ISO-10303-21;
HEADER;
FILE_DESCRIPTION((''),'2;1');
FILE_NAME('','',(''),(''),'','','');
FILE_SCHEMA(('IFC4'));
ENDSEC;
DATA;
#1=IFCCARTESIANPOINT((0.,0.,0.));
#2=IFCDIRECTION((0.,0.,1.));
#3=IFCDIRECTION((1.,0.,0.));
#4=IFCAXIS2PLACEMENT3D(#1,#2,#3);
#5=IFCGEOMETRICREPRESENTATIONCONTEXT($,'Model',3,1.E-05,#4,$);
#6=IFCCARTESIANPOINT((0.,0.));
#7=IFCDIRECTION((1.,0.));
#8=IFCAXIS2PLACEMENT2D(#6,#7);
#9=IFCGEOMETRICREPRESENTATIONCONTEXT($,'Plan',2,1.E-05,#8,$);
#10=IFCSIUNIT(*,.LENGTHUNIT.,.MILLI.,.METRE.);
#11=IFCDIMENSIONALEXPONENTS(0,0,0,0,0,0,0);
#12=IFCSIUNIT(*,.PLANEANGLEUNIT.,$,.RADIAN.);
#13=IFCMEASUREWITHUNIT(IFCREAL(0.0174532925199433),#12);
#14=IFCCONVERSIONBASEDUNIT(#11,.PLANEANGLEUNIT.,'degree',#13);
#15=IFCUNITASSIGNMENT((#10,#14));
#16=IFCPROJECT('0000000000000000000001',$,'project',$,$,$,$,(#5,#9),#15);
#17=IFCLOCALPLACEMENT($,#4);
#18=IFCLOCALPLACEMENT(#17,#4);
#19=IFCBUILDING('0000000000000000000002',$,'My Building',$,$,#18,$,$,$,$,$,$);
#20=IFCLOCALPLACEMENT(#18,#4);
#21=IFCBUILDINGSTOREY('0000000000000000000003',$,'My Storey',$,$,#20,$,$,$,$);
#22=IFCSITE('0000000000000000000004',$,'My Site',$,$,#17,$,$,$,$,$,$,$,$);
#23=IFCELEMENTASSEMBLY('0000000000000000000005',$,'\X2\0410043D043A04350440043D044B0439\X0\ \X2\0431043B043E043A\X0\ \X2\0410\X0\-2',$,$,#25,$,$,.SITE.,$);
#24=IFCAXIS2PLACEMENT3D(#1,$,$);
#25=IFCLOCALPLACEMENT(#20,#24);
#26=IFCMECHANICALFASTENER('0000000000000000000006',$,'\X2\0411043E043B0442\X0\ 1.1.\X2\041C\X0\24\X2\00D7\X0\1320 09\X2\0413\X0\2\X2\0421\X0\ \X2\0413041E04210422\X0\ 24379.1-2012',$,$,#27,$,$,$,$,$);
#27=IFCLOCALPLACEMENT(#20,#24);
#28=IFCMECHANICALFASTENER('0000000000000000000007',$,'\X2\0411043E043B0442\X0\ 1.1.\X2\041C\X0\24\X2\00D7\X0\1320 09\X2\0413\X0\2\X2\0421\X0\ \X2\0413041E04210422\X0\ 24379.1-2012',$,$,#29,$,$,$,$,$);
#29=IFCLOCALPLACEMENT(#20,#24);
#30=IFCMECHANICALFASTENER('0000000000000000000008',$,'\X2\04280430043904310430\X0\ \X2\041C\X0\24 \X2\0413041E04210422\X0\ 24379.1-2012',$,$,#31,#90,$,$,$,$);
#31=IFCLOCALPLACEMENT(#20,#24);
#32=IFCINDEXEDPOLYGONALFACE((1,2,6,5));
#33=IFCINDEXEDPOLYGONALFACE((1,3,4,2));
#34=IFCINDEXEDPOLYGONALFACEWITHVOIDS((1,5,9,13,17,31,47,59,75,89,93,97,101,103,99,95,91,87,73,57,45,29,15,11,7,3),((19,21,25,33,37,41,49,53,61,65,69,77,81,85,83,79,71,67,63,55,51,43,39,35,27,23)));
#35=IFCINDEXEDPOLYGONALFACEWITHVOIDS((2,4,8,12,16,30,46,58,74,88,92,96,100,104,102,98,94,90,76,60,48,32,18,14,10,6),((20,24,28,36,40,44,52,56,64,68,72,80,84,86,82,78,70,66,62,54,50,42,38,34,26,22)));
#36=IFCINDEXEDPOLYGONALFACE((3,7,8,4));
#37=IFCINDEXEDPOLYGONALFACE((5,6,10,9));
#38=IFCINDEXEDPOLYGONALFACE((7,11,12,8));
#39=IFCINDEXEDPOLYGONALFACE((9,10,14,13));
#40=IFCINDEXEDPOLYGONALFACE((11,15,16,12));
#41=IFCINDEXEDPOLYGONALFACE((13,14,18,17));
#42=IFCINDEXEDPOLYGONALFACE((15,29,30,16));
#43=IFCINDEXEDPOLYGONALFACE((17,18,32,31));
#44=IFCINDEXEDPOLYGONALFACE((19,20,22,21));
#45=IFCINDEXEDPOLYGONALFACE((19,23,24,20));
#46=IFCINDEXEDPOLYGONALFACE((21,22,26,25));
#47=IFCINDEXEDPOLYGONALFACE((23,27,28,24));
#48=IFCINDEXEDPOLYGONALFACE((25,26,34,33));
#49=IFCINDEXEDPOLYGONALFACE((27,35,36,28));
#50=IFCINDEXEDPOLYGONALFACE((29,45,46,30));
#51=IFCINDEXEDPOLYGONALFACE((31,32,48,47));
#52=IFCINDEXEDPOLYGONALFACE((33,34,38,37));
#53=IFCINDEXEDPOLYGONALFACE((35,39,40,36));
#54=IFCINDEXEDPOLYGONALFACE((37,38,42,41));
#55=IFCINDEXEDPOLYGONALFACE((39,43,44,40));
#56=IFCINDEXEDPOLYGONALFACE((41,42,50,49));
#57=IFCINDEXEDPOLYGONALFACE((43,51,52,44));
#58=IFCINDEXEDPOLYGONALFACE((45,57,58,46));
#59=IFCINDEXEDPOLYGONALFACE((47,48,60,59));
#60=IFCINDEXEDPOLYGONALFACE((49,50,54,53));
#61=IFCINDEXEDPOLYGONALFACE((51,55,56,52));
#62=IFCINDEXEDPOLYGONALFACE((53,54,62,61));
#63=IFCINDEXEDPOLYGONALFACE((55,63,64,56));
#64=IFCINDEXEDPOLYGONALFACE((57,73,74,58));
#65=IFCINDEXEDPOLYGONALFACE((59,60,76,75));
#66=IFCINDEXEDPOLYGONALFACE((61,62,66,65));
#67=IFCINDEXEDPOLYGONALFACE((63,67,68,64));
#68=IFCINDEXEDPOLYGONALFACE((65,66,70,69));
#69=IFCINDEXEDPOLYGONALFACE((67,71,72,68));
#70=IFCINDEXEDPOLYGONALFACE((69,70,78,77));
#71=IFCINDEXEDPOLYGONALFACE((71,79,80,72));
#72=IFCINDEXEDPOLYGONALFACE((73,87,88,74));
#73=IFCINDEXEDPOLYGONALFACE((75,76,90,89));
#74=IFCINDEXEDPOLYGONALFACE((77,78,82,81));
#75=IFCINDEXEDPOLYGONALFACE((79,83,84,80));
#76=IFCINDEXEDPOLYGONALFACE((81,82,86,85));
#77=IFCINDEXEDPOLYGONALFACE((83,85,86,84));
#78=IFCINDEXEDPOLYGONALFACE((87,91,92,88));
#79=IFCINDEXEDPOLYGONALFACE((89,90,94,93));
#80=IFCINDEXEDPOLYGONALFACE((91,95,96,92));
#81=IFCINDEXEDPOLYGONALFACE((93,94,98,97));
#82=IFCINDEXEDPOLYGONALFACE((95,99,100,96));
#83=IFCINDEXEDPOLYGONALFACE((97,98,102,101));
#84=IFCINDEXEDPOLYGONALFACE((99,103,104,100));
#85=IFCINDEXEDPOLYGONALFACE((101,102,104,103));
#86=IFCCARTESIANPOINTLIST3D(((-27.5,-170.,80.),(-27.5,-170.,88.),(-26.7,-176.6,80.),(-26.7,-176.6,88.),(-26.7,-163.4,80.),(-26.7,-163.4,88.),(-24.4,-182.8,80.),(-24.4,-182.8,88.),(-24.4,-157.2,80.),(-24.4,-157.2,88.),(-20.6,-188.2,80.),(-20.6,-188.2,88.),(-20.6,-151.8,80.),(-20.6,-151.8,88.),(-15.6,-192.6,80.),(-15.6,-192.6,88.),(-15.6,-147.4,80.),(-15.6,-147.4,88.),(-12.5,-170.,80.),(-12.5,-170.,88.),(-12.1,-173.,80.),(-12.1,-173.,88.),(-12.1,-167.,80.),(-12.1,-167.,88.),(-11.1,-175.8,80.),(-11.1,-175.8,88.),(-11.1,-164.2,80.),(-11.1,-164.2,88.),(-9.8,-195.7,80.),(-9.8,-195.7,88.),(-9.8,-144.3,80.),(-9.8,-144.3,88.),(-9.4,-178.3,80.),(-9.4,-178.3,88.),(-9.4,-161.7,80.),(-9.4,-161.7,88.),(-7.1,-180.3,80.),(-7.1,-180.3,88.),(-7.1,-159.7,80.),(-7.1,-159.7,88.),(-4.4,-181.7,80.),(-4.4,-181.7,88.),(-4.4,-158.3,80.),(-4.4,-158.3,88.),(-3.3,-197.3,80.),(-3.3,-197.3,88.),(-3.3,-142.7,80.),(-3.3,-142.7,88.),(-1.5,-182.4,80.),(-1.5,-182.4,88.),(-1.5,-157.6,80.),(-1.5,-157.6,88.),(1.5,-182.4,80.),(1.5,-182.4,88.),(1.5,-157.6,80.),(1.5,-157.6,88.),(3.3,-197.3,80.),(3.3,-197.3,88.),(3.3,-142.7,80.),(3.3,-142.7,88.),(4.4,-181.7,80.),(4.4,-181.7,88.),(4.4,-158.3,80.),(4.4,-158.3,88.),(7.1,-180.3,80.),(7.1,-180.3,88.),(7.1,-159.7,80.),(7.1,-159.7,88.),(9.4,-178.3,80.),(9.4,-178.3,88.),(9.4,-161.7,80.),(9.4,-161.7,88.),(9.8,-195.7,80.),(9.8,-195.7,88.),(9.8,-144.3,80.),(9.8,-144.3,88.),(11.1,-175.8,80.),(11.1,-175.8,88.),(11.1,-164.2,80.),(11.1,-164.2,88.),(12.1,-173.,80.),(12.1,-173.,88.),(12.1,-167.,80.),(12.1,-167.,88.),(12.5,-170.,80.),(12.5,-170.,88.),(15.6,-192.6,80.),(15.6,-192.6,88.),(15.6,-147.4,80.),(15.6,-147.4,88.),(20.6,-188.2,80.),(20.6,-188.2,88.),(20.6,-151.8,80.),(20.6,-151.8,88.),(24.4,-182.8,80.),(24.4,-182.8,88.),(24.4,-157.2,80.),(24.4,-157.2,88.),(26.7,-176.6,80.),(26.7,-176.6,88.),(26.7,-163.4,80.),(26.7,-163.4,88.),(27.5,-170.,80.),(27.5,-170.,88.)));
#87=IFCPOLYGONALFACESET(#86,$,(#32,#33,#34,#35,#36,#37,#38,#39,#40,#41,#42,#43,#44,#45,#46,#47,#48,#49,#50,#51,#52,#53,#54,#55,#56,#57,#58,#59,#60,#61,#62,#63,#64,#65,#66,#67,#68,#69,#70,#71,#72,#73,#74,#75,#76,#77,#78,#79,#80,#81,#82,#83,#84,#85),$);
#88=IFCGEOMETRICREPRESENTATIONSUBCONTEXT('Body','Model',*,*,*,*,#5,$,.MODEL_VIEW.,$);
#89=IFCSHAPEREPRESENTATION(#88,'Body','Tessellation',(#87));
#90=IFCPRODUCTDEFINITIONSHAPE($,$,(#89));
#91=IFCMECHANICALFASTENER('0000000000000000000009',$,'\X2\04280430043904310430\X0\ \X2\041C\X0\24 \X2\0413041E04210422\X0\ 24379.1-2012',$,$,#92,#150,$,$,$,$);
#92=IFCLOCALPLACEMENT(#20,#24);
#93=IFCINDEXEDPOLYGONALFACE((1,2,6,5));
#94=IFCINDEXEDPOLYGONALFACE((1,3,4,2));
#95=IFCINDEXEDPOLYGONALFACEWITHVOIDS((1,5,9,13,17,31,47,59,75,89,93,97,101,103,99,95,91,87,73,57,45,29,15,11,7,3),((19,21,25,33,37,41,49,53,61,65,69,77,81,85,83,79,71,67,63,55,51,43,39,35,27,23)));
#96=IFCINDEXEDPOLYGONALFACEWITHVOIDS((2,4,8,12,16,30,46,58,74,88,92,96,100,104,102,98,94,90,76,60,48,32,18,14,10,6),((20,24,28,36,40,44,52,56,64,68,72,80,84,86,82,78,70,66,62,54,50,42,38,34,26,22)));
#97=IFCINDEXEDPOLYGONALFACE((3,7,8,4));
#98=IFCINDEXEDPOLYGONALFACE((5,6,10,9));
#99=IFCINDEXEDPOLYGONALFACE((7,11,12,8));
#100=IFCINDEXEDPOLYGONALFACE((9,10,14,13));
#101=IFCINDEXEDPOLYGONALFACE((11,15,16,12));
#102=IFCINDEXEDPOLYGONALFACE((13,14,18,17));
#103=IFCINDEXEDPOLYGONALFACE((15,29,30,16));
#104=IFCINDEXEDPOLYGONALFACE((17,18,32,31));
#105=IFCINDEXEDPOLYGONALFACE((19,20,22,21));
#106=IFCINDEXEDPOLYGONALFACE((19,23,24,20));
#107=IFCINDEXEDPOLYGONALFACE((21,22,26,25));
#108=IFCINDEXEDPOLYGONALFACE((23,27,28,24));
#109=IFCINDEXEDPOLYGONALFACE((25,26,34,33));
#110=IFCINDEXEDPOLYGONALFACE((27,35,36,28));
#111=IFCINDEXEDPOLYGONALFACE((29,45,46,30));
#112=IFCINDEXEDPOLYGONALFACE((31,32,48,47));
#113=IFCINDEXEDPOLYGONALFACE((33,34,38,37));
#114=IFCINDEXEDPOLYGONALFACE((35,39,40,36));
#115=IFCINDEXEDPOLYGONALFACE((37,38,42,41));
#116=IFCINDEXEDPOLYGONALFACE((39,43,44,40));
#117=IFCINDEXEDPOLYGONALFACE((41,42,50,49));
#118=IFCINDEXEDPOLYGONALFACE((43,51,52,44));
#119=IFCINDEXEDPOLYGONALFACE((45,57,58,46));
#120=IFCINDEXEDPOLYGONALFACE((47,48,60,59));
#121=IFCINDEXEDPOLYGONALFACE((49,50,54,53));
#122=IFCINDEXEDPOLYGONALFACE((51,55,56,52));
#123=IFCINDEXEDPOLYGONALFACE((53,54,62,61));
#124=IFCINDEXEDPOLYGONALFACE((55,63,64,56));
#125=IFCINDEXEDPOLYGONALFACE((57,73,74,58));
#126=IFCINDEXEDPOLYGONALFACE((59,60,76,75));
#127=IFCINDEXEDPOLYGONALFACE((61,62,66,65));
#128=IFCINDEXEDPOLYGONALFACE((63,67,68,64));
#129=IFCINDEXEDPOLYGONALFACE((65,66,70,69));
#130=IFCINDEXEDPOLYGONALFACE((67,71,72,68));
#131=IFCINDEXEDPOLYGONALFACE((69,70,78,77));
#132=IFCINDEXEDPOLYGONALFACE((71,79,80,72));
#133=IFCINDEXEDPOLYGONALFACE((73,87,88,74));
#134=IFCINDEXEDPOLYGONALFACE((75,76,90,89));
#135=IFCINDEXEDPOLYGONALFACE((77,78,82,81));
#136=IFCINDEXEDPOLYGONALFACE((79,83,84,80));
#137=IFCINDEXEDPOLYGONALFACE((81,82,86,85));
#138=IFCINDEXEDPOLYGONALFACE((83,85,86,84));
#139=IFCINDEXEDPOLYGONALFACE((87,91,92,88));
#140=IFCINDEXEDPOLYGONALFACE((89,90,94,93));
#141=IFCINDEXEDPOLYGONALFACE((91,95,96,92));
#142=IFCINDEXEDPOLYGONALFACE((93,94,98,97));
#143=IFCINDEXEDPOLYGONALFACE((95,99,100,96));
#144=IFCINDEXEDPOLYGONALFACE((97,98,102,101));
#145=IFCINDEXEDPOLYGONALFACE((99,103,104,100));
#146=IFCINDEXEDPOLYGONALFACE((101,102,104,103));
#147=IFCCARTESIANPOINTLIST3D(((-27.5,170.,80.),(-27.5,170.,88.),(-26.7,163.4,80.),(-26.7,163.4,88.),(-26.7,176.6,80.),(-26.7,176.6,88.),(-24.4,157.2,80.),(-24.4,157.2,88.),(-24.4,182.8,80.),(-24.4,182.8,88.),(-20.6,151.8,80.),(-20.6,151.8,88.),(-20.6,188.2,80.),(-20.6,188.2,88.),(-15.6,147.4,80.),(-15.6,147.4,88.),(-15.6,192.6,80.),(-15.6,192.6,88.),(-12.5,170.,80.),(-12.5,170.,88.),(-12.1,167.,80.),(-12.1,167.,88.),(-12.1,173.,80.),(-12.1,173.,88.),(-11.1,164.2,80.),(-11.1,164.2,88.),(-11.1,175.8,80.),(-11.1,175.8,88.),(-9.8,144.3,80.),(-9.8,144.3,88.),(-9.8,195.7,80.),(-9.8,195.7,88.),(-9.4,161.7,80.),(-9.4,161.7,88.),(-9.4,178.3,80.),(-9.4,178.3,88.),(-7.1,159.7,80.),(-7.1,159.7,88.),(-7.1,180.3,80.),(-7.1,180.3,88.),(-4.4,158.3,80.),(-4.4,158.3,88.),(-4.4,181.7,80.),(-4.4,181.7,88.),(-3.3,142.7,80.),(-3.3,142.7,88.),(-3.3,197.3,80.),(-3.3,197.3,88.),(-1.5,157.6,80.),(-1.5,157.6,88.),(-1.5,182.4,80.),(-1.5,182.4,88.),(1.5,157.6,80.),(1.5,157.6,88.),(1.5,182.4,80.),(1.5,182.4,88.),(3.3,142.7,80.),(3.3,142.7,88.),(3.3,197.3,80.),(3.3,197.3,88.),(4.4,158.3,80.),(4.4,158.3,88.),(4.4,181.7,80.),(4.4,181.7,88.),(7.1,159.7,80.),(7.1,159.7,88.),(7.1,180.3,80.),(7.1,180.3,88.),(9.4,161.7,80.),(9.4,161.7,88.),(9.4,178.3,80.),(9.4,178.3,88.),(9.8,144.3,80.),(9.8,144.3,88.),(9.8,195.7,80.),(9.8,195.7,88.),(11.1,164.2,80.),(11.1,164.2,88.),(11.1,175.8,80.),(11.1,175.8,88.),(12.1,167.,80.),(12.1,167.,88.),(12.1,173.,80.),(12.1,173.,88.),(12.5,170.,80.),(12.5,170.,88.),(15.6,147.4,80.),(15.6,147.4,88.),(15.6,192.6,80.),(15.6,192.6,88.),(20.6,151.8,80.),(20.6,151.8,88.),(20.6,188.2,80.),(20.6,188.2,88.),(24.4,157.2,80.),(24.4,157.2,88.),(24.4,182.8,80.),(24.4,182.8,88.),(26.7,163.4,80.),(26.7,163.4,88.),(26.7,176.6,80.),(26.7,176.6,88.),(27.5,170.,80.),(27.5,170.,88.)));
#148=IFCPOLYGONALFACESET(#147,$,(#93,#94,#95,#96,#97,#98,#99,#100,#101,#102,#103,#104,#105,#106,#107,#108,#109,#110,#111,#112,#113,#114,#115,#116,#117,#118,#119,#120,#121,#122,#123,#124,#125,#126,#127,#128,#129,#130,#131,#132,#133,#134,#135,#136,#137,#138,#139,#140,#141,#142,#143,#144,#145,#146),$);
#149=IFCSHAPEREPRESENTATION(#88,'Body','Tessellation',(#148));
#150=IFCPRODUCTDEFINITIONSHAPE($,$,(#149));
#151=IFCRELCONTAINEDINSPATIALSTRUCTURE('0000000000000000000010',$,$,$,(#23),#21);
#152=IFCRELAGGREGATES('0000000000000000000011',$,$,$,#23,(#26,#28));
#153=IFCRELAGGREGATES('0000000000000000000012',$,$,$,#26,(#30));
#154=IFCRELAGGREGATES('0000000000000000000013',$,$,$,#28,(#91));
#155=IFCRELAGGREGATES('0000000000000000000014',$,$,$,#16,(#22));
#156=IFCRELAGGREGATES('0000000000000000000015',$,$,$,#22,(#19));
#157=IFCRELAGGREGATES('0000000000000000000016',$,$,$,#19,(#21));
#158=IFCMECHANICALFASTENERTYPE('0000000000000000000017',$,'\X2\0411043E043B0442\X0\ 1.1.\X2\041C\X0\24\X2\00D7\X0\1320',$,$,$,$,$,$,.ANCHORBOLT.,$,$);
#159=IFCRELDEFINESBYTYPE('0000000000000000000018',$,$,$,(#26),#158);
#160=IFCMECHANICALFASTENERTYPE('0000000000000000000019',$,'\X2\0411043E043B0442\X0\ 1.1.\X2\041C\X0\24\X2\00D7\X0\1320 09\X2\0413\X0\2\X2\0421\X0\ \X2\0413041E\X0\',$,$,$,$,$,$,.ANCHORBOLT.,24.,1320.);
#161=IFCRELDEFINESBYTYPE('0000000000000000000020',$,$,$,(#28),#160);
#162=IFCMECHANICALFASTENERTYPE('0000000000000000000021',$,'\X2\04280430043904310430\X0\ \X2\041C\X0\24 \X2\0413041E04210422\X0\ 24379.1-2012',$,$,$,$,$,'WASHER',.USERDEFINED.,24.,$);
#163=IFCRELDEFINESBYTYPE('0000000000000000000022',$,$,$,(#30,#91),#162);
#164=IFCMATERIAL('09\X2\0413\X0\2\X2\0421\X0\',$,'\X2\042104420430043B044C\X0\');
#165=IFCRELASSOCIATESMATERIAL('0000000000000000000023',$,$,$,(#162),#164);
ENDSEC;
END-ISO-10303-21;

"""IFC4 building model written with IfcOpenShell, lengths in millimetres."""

from ifc_helpers import new_model, entity, si_unit, converted_unit, frame, origin_with_axes, origin_2d_with_axis, place, context, subcontext, project, spatial, polyline, outline, extrude, source, transform, mapped, material, type_object, type_shapes, element, aggregate, save


model = new_model("IFC4")

# Units and contexts
model_context = context("Model", 3, precision=1e-05, world=origin_with_axes())
plan_context = context("Plan", 2, precision=1e-05, world=origin_2d_with_axis())
body_context = subcontext(model_context, "Body", "Model", "MODEL_VIEW")
ifc_project = project(units=[si_unit("LENGTHUNIT", "METRE", prefix="MILLI"), converted_unit("PLANEANGLEUNIT", "degree", entity("IfcReal", 0.0174532925199433), si_unit("PLANEANGLEUNIT", "RADIAN"), dimensions=[0, 0, 0, 0, 0, 0, 0])], contexts=[model_context, plan_context])

# Site, building, storey
site_placement = place(None, origin_with_axes())
site = spatial("IfcSite", under=ifc_project, at=site_placement, Name="My Site")
building_placement = place(site_placement, origin_with_axes())
building = spatial("IfcBuilding", under=site, at=building_placement, Name="My Building")
storey_placement = place(building_placement, origin_with_axes())
storey = spatial("IfcBuildingStorey", under=building, at=storey_placement, Name="My Storey")

# Shared definitions
placement_1 = place(storey_placement, origin_with_axes())

# Element assembly, mechanical fasteners
assembly_1 = element("IfcElementAssembly", 1, at=placement_1, inside=storey, Name="Анкерный блок А-2", AssemblyPlace="SITE")
mechanical_fastener_type_1 = type_object("IfcMechanicalFastenerType", Name="Болт 1.1.М24×1320", PredefinedType="ANCHORBOLT")
mechanical_fastener_1_placement = place(placement_1, frame((0.0, -170.0, 0.0), z_axis=(0.0, 0.0, 1.0), x_axis=(1.0, 0.0, 0.0)))
mechanical_fastener_1 = element("IfcMechanicalFastener", 2, at=mechanical_fastener_1_placement, type_object=mechanical_fastener_type_1, Name="Болт 1.1.М24×1320 09Г2С ГОСТ 24379.1-2012")
ifc_material_1 = material(Name="09Г2С", Category="Сталь")
mechanical_fastener_type_2 = type_object("IfcMechanicalFastenerType", Name="Болт 1.1.М24×1320 09Г2С ГО", NominalDiameter=24.0, NominalLength=1320.0, PredefinedType="ANCHORBOLT")
mechanical_fastener_2_placement = place(placement_1, frame((0.0, 170.0, 0.0), z_axis=(0.0, 0.0, 1.0), x_axis=(-1.0, 0.0, 0.0)))
mechanical_fastener_2 = element("IfcMechanicalFastener", 3, at=mechanical_fastener_2_placement, type_object=mechanical_fastener_type_2, Name="Болт 1.1.М24×1320 09Г2С ГОСТ 24379.1-2012")
aggregate(assembly_1, [mechanical_fastener_1, mechanical_fastener_2])

# Mechanical fasteners
mechanical_fastener_type_3 = type_object("IfcMechanicalFastenerType", Name="Шайба М24 ГОСТ 24379.1-2012", ElementType="WASHER", NominalDiameter=24.0, PredefinedType="USERDEFINED", material=ifc_material_1)
shared_shape_1 = source(origin_with_axes(), body_context, "Body", "SweptSolid", [
    extrude(outline(polyline([(27.5, 0.0), (26.7, 6.6), (24.4, 12.8), (20.6, 18.2), (15.6, 22.6), (9.8, 25.7), (3.3, 27.3), (-3.3, 27.3), (-9.8, 25.7), (-15.6, 22.6), (-20.6, 18.2), (-24.4, 12.8), (-26.7, 6.6), (-27.5, 0.0), (-26.7, -6.6), (-24.4, -12.8), (-20.6, -18.2), (-15.6, -22.6), (-9.8, -25.7), (-3.3, -27.3), (3.3, -27.3), (9.8, -25.7), (15.6, -22.6), (20.6, -18.2), (24.4, -12.8), (26.7, -6.6), (27.5, 0.0)]), holes=[polyline([(-4.4, -11.7), (-7.1, -10.3), (-9.4, -8.3), (-11.1, -5.8), (-12.1, -3.0), (-12.5, 0.0), (-12.1, 3.0), (-11.1, 5.8), (-9.4, 8.3), (-7.1, 10.3), (-4.4, 11.7), (-1.5, 12.4), (1.5, 12.4), (4.4, 11.7), (7.1, 10.3), (9.4, 8.3), (11.1, 5.8), (12.1, 3.0), (12.5, 0.0), (12.1, -3.0), (11.1, -5.8), (9.4, -8.3), (7.1, -10.3), (4.4, -11.7), (1.5, -12.4), (-1.5, -12.4), (-4.4, -11.7)])]), frame((0.0, 0.0, 0.0), z_axis=(0.0, 0.0, 1.0), x_axis=(0.120537, -0.992709, 0.0)), (0.0, 0.0, 1.0), 8.0),
])
type_shapes(mechanical_fastener_type_3, [shared_shape_1])
mechanical_fastener_3_placement = place(mechanical_fastener_1_placement, frame((0.0, 0.0, 80.0), z_axis=(0.0, 0.0, 1.0), x_axis=(1.0, 0.0, 0.0)))
mechanical_fastener_3 = element("IfcMechanicalFastener", 4, at=mechanical_fastener_3_placement, type_object=mechanical_fastener_type_3, Name="Шайба М24 ГОСТ 24379.1-2012", context=body_context, shape_type="MappedRepresentation", body=[
    mapped(shared_shape_1, transform((0.0, 0.0, 0.0), x_axis=(1.0, 0.0, 0.0), y_axis=(0.0, 1.0, 0.0), z_axis=(0.0, 0.0, 1.0), scale=1.0)),
])
aggregate(mechanical_fastener_1, [mechanical_fastener_3])
mechanical_fastener_4_placement = place(mechanical_fastener_2_placement, frame((0.0, 0.0, 80.0), z_axis=(0.0, 0.0, 1.0), x_axis=(1.0, 0.0, 0.0)))
mechanical_fastener_4 = element("IfcMechanicalFastener", 5, at=mechanical_fastener_4_placement, type_object=mechanical_fastener_type_3, Name="Шайба М24 ГОСТ 24379.1-2012", context=body_context, shape_type="MappedRepresentation", body=[
    mapped(shared_shape_1, transform((0.0, 0.0, 0.0), x_axis=(1.0, 0.0, 0.0), y_axis=(0.0, 1.0, 0.0), z_axis=(0.0, 0.0, 1.0), scale=1.0)),
])
aggregate(mechanical_fastener_2, [mechanical_fastener_4])

save(model, "model.ifc")
